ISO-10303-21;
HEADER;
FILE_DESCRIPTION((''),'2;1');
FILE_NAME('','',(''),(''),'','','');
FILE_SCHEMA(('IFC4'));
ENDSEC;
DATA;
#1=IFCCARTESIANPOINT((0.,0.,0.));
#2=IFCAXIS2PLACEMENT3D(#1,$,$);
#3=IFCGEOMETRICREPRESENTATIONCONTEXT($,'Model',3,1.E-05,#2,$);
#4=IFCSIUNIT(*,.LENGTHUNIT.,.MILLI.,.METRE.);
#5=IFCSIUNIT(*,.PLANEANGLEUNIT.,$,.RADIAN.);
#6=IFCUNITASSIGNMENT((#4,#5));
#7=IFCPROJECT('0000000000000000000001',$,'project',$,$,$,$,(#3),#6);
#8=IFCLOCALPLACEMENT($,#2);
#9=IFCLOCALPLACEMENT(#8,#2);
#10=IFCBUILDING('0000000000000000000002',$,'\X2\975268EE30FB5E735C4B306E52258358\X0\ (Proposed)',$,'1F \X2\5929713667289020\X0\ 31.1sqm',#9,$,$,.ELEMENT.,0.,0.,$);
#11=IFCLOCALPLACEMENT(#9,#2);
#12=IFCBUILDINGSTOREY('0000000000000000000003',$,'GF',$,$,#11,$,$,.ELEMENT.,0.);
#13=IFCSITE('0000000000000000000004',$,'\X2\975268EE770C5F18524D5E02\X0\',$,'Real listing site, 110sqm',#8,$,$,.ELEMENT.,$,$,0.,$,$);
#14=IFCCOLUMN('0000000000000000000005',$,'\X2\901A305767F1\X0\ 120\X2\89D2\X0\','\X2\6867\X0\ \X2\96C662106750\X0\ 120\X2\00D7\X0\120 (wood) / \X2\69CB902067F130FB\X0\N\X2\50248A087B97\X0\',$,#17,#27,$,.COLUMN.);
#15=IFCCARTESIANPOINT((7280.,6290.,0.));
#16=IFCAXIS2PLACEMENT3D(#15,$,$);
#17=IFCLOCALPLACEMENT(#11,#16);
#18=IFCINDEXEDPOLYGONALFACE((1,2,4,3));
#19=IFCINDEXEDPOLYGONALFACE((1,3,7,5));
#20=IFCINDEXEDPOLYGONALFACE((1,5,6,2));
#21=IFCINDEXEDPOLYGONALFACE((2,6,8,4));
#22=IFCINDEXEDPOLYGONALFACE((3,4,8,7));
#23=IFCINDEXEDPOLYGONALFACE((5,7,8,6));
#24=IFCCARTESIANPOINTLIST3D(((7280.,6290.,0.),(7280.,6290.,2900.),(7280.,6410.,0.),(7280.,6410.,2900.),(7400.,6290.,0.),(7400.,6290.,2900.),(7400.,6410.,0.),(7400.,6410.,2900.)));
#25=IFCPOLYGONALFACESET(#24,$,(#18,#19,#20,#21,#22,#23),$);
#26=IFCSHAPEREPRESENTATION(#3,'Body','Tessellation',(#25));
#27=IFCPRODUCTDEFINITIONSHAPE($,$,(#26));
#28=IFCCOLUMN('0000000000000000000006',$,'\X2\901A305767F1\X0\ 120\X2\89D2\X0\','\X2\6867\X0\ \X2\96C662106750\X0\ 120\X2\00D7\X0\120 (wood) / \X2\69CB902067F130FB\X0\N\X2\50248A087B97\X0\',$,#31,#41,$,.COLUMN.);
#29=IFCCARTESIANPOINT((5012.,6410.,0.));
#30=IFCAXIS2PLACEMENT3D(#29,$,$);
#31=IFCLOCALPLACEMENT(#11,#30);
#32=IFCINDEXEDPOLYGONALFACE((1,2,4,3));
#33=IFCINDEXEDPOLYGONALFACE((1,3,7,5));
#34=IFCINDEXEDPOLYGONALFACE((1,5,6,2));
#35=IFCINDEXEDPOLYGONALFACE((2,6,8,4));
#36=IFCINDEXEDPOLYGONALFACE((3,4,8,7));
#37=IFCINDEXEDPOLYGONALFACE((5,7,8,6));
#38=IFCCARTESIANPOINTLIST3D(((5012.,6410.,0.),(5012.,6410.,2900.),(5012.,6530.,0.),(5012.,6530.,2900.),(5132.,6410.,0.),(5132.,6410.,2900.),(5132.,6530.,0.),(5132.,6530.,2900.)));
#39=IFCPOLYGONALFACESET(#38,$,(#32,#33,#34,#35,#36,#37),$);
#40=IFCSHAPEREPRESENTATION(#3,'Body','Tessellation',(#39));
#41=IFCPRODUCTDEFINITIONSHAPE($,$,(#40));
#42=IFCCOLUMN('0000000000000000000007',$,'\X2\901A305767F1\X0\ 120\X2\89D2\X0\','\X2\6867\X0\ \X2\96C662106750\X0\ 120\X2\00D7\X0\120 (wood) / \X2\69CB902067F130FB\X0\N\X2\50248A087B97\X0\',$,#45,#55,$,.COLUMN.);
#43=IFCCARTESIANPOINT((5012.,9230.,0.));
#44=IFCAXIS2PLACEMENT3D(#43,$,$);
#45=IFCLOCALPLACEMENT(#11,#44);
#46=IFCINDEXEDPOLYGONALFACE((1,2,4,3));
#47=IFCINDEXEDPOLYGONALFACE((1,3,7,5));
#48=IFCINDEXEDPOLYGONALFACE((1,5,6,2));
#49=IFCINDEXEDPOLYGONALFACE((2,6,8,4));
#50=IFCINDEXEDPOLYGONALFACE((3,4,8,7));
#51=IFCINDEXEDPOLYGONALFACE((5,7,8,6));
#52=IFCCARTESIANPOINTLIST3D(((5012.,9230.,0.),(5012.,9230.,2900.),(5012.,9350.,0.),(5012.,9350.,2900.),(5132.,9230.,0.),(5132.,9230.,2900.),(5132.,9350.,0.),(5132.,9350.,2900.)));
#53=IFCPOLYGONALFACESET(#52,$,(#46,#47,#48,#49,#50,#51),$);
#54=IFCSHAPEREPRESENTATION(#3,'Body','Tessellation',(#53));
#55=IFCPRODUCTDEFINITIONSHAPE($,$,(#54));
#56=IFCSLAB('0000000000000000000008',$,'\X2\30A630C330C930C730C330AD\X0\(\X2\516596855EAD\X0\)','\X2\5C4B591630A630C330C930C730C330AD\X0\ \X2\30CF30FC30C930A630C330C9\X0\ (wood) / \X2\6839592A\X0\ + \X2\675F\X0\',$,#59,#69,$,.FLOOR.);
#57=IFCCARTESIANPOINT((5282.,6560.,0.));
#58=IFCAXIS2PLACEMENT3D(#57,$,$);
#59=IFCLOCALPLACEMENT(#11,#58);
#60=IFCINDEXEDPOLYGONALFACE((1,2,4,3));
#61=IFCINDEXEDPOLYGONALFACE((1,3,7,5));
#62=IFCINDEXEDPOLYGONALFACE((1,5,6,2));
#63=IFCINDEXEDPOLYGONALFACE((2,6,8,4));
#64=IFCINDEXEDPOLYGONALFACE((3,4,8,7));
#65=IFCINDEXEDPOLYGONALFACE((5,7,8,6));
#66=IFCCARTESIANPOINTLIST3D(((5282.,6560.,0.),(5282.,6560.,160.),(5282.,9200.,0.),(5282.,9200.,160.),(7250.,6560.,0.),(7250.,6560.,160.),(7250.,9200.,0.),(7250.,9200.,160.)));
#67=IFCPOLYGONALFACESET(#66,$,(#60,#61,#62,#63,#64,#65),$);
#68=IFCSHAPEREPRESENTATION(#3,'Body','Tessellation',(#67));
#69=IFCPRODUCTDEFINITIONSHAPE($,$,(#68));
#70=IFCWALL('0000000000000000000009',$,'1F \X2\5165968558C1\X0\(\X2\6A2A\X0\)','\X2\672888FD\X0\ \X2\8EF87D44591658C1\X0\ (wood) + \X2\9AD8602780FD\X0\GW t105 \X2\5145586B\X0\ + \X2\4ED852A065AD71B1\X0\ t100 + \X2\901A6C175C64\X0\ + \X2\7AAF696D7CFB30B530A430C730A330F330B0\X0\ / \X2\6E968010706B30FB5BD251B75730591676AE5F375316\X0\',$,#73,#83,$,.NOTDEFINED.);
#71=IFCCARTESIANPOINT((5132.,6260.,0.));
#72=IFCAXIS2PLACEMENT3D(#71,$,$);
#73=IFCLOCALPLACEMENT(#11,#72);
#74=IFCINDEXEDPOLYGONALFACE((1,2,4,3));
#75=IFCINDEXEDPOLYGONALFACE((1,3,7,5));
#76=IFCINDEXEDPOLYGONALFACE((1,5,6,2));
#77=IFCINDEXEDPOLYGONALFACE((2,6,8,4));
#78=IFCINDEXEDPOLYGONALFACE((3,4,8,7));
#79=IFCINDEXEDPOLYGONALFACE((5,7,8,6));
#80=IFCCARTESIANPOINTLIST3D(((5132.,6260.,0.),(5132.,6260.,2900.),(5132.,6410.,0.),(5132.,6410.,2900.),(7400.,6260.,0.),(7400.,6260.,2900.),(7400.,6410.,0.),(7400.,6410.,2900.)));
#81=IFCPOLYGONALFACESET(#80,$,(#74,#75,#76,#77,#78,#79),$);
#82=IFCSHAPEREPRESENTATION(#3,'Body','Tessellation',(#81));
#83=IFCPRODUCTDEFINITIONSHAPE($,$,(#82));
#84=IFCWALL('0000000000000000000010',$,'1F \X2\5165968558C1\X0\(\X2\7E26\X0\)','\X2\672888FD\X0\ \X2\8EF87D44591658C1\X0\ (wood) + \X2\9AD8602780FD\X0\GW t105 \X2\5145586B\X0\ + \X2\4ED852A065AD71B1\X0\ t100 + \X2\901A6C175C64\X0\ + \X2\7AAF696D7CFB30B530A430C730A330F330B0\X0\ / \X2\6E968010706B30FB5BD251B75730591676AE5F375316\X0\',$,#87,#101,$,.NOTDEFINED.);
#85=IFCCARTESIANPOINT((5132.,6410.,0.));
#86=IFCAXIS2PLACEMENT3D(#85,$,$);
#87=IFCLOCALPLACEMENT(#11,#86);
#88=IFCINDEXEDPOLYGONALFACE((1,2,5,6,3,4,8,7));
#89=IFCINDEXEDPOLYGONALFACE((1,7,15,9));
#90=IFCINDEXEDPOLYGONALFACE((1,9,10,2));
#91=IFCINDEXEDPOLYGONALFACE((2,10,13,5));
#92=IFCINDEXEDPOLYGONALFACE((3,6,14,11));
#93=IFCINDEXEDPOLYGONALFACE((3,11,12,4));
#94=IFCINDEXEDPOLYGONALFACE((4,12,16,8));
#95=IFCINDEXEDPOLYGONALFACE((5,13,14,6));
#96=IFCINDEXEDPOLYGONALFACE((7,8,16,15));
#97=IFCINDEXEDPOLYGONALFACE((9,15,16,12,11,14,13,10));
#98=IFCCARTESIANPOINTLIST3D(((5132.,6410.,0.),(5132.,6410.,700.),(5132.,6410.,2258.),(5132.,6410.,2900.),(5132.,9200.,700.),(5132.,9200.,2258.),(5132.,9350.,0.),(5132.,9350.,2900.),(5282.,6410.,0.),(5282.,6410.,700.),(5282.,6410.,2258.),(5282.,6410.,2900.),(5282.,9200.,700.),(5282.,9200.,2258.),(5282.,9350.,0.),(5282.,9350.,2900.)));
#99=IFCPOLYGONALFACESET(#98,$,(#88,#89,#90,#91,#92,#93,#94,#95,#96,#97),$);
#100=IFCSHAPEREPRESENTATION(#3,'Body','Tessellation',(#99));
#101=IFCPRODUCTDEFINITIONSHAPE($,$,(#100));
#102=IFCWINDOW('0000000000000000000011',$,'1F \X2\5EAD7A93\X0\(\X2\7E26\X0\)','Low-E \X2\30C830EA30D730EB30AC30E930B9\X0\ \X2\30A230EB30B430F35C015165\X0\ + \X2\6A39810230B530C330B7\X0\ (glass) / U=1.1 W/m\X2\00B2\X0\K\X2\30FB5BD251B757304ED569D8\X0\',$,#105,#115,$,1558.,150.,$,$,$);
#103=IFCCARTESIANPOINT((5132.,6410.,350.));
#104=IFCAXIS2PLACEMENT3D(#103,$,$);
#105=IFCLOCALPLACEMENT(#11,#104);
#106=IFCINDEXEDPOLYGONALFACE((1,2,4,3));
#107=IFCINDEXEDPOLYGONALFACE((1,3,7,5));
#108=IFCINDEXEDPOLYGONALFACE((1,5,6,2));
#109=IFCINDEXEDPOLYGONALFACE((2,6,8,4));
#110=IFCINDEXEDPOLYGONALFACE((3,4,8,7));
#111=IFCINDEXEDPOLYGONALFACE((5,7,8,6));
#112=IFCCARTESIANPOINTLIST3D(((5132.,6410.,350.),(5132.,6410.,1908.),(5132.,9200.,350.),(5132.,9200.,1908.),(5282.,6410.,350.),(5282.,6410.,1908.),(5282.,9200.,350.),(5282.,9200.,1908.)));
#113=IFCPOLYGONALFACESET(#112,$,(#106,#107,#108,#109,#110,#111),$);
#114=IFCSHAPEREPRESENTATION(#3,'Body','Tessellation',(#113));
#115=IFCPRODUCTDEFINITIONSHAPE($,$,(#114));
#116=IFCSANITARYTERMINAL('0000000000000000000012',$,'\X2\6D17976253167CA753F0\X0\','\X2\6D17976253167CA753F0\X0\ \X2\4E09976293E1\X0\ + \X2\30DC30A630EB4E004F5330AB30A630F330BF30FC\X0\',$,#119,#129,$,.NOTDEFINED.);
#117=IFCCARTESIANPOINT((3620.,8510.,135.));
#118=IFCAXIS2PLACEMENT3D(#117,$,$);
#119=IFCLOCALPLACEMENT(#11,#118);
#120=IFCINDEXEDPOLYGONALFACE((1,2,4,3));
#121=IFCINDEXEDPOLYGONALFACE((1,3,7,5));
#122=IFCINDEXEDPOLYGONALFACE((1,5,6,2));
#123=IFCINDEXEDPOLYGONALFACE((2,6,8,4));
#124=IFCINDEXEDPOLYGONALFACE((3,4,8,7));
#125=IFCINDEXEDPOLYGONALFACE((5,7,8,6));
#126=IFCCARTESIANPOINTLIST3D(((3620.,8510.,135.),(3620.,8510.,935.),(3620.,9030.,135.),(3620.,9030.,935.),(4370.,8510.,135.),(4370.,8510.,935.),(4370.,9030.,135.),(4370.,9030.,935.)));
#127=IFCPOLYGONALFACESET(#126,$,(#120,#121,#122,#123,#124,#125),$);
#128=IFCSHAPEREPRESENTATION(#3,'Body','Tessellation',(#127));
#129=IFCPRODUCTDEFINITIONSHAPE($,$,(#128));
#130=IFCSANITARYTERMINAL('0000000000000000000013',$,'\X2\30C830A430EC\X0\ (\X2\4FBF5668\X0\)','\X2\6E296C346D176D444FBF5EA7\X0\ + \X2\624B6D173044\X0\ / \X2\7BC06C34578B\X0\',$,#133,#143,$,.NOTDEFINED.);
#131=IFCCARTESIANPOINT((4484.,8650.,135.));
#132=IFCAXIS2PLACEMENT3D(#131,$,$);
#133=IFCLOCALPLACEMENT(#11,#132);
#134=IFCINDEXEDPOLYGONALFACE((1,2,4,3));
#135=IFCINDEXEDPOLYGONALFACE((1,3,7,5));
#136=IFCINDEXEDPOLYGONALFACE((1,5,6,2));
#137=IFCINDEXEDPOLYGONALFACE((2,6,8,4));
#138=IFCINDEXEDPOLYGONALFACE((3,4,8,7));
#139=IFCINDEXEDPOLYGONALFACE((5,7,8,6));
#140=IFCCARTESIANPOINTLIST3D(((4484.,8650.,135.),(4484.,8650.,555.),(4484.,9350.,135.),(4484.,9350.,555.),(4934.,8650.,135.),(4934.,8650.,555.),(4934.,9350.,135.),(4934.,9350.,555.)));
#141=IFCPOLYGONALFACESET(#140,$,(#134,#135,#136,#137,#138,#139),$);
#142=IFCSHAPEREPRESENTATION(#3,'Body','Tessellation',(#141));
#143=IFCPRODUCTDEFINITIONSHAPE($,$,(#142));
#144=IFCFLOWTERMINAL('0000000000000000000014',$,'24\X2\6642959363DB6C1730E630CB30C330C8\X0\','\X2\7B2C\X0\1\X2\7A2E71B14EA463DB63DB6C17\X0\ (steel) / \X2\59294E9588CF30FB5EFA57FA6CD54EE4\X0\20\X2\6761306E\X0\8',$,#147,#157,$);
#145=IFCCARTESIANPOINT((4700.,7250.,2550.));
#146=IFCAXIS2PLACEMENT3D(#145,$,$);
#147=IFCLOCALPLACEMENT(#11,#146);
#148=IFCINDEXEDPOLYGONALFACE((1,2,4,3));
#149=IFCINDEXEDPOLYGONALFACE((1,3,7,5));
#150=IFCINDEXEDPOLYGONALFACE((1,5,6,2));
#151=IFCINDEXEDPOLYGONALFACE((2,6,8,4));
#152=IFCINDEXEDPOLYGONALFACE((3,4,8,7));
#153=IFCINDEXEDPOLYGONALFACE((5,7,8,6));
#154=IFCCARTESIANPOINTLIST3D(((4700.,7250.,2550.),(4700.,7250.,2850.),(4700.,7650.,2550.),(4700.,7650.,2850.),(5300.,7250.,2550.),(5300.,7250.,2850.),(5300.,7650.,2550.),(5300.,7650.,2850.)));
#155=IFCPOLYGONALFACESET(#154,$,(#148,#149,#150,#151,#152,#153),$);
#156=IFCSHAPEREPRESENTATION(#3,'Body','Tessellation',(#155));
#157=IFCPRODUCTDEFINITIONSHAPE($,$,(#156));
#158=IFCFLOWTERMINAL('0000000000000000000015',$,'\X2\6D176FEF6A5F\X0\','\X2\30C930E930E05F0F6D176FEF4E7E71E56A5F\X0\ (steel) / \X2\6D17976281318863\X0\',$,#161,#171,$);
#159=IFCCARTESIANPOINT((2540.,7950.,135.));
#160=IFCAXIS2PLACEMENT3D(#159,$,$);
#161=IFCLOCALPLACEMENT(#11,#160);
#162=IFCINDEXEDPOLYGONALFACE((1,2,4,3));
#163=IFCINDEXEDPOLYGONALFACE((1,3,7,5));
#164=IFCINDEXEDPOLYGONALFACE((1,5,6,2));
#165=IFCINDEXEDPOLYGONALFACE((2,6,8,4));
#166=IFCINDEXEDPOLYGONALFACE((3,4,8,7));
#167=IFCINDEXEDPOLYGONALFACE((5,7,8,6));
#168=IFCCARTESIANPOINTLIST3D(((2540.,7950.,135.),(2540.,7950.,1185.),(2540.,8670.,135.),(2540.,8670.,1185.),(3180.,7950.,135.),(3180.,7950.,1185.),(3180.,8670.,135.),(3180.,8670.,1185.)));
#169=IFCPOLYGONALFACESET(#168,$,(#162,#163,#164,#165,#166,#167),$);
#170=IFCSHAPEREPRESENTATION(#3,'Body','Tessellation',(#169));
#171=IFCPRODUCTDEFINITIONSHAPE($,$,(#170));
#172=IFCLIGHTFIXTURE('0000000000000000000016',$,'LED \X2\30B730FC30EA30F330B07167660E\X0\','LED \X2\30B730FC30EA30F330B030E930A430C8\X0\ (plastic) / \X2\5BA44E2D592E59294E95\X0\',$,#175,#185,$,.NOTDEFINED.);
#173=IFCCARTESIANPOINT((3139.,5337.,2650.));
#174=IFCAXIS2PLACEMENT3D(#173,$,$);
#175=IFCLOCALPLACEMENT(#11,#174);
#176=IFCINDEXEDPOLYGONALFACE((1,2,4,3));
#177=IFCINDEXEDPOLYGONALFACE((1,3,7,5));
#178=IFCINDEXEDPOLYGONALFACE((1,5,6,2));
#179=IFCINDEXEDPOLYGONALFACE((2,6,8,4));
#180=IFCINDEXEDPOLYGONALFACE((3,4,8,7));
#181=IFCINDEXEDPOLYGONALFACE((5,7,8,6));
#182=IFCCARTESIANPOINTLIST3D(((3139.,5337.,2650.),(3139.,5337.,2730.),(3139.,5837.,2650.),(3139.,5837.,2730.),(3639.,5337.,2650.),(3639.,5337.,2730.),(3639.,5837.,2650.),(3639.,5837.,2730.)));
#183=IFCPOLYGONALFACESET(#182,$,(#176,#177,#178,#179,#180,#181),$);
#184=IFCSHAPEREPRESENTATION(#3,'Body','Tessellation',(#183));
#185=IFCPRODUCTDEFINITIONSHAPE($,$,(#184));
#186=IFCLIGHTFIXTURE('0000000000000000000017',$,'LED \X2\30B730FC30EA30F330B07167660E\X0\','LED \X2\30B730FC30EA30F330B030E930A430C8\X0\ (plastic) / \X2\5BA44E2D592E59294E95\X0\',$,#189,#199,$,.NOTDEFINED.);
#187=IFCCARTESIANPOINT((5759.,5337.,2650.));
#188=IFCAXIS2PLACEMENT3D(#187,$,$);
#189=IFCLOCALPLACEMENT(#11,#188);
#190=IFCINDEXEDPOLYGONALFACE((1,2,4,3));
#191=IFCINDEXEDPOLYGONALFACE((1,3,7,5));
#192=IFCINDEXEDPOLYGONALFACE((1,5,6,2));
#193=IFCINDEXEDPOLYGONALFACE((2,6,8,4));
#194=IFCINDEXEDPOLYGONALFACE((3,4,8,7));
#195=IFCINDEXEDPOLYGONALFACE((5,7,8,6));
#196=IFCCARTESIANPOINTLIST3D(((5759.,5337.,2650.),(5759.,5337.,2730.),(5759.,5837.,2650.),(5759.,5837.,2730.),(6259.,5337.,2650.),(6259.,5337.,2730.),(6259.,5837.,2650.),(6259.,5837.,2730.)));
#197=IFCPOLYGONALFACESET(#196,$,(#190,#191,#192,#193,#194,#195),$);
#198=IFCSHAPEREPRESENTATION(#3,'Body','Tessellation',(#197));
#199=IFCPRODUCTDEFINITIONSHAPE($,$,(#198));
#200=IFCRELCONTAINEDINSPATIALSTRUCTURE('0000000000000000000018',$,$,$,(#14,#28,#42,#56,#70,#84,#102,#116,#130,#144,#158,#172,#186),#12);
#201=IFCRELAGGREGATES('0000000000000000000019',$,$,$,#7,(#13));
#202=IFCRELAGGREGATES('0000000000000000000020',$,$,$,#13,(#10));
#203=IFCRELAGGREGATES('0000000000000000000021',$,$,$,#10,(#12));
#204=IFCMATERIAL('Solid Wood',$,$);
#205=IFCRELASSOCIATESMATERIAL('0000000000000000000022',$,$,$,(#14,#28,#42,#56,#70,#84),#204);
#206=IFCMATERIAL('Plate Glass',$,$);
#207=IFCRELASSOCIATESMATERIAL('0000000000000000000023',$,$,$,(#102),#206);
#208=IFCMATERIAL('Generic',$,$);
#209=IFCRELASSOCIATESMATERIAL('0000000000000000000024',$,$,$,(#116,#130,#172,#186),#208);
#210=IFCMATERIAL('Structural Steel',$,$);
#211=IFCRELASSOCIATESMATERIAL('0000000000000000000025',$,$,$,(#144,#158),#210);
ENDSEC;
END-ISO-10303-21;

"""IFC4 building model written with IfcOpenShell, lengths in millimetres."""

from ifc_helpers import new_model, si_unit, frame, frame_2d, origin, place, context, project, spatial, rectangle, extrude, material, element, fill, save


model = new_model("IFC4")

# Units and contexts
model_context = context("Model", 3, precision=1e-05, world=origin())
ifc_project = project(units=[si_unit("LENGTHUNIT", "METRE", prefix="MILLI"), si_unit("PLANEANGLEUNIT", "RADIAN")], contexts=[model_context])

# Site, building, storey
site_placement = place(None, origin())
site = spatial("IfcSite", under=ifc_project, at=site_placement, Name="青森県弘前市", ObjectType="Real listing site, 110sqm", CompositionType="ELEMENT", RefElevation=0.0)
building_placement = place(site_placement, origin())
building = spatial("IfcBuilding", under=site, at=building_placement, Name="青森・平屋の別荘 (Proposed)", ObjectType="1F 天然木造 31.1sqm", CompositionType="ELEMENT", ElevationOfRefHeight=0.0, ElevationOfTerrain=0.0)
storey_placement = place(building_placement, origin())
storey = spatial("IfcBuildingStorey", under=building, at=storey_placement, Name="GF", CompositionType="ELEMENT", Elevation=0.0)

# Columns
ifc_material_1 = material(Name="Solid Wood")
column_1_placement = place(storey_placement, frame((7280.0, 6290.0, 0.0)))
element("IfcColumn", 1, at=column_1_placement, inside=storey, material=ifc_material_1, Name="通し柱 120角", Description="桧 集成材 120×120 (wood) / 構造柱・N値計算", PredefinedType="COLUMN", context=model_context, shape_type="SweptSolid", body=[
    extrude(rectangle(XDim=120.0, YDim=120.0, at=frame_2d((60.0, 60.0))), frame((7280.0, 6290.0, 0.0)), (0.0, 0.0, 1.0), 2900.0),
])
column_2_placement = place(storey_placement, frame((5012.0, 6410.0, 0.0)))
element("IfcColumn", 2, at=column_2_placement, inside=storey, material=ifc_material_1, Name="通し柱 120角", Description="桧 集成材 120×120 (wood) / 構造柱・N値計算", PredefinedType="COLUMN", context=model_context, shape_type="SweptSolid", body=[
    extrude(rectangle(XDim=120.0, YDim=120.0, at=frame_2d((60.0, 60.0))), frame((5012.0, 6410.0, 0.0)), (0.0, 0.0, 1.0), 2900.0),
])
column_3_placement = place(storey_placement, frame((5012.0, 9230.0, 0.0)))
element("IfcColumn", 3, at=column_3_placement, inside=storey, material=ifc_material_1, Name="通し柱 120角", Description="桧 集成材 120×120 (wood) / 構造柱・N値計算", PredefinedType="COLUMN", context=model_context, shape_type="SweptSolid", body=[
    extrude(rectangle(XDim=120.0, YDim=120.0, at=frame_2d((60.0, 60.0))), frame((5012.0, 9230.0, 0.0)), (0.0, 0.0, 1.0), 2900.0),
])

# Slab
slab_placement = place(storey_placement, frame((5282.0, 6560.0, 0.0)))
element("IfcSlab", 4, at=slab_placement, inside=storey, material=ifc_material_1, Name="ウッドデッキ(入隅庭)", Description="屋外ウッドデッキ ハードウッド (wood) / 根太 + 束", PredefinedType="FLOOR", context=model_context, shape_type="SweptSolid", body=[
    extrude(rectangle(XDim=1968.0, YDim=2640.0, at=frame_2d((984.0, 1320.0))), frame((5282.0, 6560.0, 0.0)), (0.0, 0.0, 1.0), 160.0),
])

# Wall
wall_1_placement = place(storey_placement, frame((5132.0, 6260.0, 0.0)))
element("IfcWall", 5, at=wall_1_placement, inside=storey, material=ifc_material_1, Name="1F 入隅壁(横)", Description="木製 軸組外壁 (wood) + 高性能GW t105 充填 + 付加断熱 t100 + 通気層 + 窯業系サイディング / 準耐火・寒冷地外皮強化", PredefinedType="NOTDEFINED", context=model_context, shape_type="SweptSolid", body=[
    extrude(rectangle(XDim=2268.0, YDim=150.0, at=frame_2d((1134.0, 75.0))), frame((5132.0, 6260.0, 0.0)), (0.0, 0.0, 1.0), 2900.0),
])

# Wall, opening, window
wall_2_placement = place(storey_placement, frame((5132.0, 6410.0, 0.0)))
wall_2 = element("IfcWall", 6, at=wall_2_placement, inside=storey, material=ifc_material_1, Name="1F 入隅壁(縦)", Description="木製 軸組外壁 (wood) + 高性能GW t105 充填 + 付加断熱 t100 + 通気層 + 窯業系サイディング / 準耐火・寒冷地外皮強化", PredefinedType="NOTDEFINED", context=model_context, shape_type="SweptSolid", body=[
    extrude(rectangle(XDim=150.0, YDim=2940.0, at=frame_2d((75.0, 1470.0))), frame((5132.0, 6410.0, 0.0)), (0.0, 0.0, 1.0), 2900.0),
])
opening_placement = place(storey_placement, frame((5132.0, 6410.0, 350.0)))
opening = element("IfcOpeningElement", 7, at=opening_placement, cuts=wall_2, PredefinedType="NOTDEFINED", context=model_context, shape_type="SweptSolid", body=[
    extrude(rectangle(XDim=150.0, YDim=2790.0, at=frame_2d((75.0, 1395.0))), frame((5132.0, 6410.0, 350.0)), (0.0, 0.0, 1.0), 1558.0),
])
ifc_material_2 = material(Name="Plate Glass")
window_placement = place(storey_placement, frame((5132.0, 6410.0, 350.0)))
window = element("IfcWindow", 8, at=window_placement, inside=storey, material=ifc_material_2, Name="1F 庭窓(縦)", Description="Low-E トリプルガラス アルゴン封入 + 樹脂サッシ (glass) / U=1.1 W/m²K・寒冷地仕様", OverallHeight=1558.0, OverallWidth=150.0, context=model_context, shape_type="SweptSolid", body=[
    extrude(rectangle(XDim=150.0, YDim=2790.0, at=frame_2d((75.0, 1395.0))), frame((5132.0, 6410.0, 350.0)), (0.0, 0.0, 1.0), 1558.0),
])
fill(opening, window)

# Sanitary terminals
ifc_material_3 = material(Name="Generic")
sanitary_terminal_1_placement = place(storey_placement, frame((3620.0, 8510.0, 135.0)))
element("IfcSanitaryTerminal", 9, at=sanitary_terminal_1_placement, inside=storey, material=ifc_material_3, Name="洗面化粧台", Description="洗面化粧台 三面鏡 + ボウル一体カウンター", PredefinedType="NOTDEFINED", context=model_context, shape_type="SweptSolid", body=[
    extrude(rectangle(XDim=750.0, YDim=520.0, at=frame_2d((375.0, 260.0))), frame((3620.0, 8510.0, 135.0)), (0.0, 0.0, 1.0), 800.0),
])
sanitary_terminal_2_placement = place(storey_placement, frame((4484.0, 8650.0, 135.0)))
element("IfcSanitaryTerminal", 10, at=sanitary_terminal_2_placement, inside=storey, material=ifc_material_3, Name="トイレ (便器)", Description="温水洗浄便座 + 手洗い / 節水型", PredefinedType="NOTDEFINED", context=model_context, shape_type="SweptSolid", body=[
    extrude(rectangle(XDim=450.0, YDim=700.0, at=frame_2d((225.0, 350.0))), frame((4484.0, 8650.0, 135.0)), (0.0, 0.0, 1.0), 420.0),
])

# Flow terminals
ifc_material_4 = material(Name="Structural Steel")
flow_terminal_1_placement = place(storey_placement, frame((4700.0, 7250.0, 2550.0)))
element("IfcFlowTerminal", 11, at=flow_terminal_1_placement, inside=storey, material=ifc_material_4, Name="24時間換気ユニット", Description="第1種熱交換換気 (steel) / 天井裏・建基法令20条の8", context=model_context, shape_type="SweptSolid", body=[
    extrude(rectangle(XDim=600.0, YDim=400.0, at=frame_2d((300.0, 200.0))), frame((4700.0, 7250.0, 2550.0)), (0.0, 0.0, 1.0), 300.0),
])
flow_terminal_2_placement = place(storey_placement, frame((2540.0, 7950.0, 135.0)))
element("IfcFlowTerminal", 12, at=flow_terminal_2_placement, inside=storey, material=ifc_material_4, Name="洗濯機", Description="ドラム式洗濯乾燥機 (steel) / 洗面脱衣", context=model_context, shape_type="SweptSolid", body=[
    extrude(rectangle(XDim=640.0, YDim=720.0, at=frame_2d((320.0, 360.0))), frame((2540.0, 7950.0, 135.0)), (0.0, 0.0, 1.0), 1050.0),
])

# Light fixtures
light_fixture_1_placement = place(storey_placement, frame((3139.0, 5337.0, 2650.0)))
element("IfcLightFixture", 13, at=light_fixture_1_placement, inside=storey, material=ifc_material_3, Name="LED シーリング照明", Description="LED シーリングライト (plastic) / 室中央天井", PredefinedType="NOTDEFINED", context=model_context, shape_type="SweptSolid", body=[
    extrude(rectangle(XDim=500.0, YDim=500.0, at=frame_2d((250.0, 250.0))), frame((3139.0, 5337.0, 2650.0)), (0.0, 0.0, 1.0), 80.0),
])
light_fixture_2_placement = place(storey_placement, frame((5759.0, 5337.0, 2650.0)))
element("IfcLightFixture", 14, at=light_fixture_2_placement, inside=storey, material=ifc_material_3, Name="LED シーリング照明", Description="LED シーリングライト (plastic) / 室中央天井", PredefinedType="NOTDEFINED", context=model_context, shape_type="SweptSolid", body=[
    extrude(rectangle(XDim=500.0, YDim=500.0, at=frame_2d((250.0, 250.0))), frame((5759.0, 5337.0, 2650.0)), (0.0, 0.0, 1.0), 80.0),
])

save(model, "model.ifc")
